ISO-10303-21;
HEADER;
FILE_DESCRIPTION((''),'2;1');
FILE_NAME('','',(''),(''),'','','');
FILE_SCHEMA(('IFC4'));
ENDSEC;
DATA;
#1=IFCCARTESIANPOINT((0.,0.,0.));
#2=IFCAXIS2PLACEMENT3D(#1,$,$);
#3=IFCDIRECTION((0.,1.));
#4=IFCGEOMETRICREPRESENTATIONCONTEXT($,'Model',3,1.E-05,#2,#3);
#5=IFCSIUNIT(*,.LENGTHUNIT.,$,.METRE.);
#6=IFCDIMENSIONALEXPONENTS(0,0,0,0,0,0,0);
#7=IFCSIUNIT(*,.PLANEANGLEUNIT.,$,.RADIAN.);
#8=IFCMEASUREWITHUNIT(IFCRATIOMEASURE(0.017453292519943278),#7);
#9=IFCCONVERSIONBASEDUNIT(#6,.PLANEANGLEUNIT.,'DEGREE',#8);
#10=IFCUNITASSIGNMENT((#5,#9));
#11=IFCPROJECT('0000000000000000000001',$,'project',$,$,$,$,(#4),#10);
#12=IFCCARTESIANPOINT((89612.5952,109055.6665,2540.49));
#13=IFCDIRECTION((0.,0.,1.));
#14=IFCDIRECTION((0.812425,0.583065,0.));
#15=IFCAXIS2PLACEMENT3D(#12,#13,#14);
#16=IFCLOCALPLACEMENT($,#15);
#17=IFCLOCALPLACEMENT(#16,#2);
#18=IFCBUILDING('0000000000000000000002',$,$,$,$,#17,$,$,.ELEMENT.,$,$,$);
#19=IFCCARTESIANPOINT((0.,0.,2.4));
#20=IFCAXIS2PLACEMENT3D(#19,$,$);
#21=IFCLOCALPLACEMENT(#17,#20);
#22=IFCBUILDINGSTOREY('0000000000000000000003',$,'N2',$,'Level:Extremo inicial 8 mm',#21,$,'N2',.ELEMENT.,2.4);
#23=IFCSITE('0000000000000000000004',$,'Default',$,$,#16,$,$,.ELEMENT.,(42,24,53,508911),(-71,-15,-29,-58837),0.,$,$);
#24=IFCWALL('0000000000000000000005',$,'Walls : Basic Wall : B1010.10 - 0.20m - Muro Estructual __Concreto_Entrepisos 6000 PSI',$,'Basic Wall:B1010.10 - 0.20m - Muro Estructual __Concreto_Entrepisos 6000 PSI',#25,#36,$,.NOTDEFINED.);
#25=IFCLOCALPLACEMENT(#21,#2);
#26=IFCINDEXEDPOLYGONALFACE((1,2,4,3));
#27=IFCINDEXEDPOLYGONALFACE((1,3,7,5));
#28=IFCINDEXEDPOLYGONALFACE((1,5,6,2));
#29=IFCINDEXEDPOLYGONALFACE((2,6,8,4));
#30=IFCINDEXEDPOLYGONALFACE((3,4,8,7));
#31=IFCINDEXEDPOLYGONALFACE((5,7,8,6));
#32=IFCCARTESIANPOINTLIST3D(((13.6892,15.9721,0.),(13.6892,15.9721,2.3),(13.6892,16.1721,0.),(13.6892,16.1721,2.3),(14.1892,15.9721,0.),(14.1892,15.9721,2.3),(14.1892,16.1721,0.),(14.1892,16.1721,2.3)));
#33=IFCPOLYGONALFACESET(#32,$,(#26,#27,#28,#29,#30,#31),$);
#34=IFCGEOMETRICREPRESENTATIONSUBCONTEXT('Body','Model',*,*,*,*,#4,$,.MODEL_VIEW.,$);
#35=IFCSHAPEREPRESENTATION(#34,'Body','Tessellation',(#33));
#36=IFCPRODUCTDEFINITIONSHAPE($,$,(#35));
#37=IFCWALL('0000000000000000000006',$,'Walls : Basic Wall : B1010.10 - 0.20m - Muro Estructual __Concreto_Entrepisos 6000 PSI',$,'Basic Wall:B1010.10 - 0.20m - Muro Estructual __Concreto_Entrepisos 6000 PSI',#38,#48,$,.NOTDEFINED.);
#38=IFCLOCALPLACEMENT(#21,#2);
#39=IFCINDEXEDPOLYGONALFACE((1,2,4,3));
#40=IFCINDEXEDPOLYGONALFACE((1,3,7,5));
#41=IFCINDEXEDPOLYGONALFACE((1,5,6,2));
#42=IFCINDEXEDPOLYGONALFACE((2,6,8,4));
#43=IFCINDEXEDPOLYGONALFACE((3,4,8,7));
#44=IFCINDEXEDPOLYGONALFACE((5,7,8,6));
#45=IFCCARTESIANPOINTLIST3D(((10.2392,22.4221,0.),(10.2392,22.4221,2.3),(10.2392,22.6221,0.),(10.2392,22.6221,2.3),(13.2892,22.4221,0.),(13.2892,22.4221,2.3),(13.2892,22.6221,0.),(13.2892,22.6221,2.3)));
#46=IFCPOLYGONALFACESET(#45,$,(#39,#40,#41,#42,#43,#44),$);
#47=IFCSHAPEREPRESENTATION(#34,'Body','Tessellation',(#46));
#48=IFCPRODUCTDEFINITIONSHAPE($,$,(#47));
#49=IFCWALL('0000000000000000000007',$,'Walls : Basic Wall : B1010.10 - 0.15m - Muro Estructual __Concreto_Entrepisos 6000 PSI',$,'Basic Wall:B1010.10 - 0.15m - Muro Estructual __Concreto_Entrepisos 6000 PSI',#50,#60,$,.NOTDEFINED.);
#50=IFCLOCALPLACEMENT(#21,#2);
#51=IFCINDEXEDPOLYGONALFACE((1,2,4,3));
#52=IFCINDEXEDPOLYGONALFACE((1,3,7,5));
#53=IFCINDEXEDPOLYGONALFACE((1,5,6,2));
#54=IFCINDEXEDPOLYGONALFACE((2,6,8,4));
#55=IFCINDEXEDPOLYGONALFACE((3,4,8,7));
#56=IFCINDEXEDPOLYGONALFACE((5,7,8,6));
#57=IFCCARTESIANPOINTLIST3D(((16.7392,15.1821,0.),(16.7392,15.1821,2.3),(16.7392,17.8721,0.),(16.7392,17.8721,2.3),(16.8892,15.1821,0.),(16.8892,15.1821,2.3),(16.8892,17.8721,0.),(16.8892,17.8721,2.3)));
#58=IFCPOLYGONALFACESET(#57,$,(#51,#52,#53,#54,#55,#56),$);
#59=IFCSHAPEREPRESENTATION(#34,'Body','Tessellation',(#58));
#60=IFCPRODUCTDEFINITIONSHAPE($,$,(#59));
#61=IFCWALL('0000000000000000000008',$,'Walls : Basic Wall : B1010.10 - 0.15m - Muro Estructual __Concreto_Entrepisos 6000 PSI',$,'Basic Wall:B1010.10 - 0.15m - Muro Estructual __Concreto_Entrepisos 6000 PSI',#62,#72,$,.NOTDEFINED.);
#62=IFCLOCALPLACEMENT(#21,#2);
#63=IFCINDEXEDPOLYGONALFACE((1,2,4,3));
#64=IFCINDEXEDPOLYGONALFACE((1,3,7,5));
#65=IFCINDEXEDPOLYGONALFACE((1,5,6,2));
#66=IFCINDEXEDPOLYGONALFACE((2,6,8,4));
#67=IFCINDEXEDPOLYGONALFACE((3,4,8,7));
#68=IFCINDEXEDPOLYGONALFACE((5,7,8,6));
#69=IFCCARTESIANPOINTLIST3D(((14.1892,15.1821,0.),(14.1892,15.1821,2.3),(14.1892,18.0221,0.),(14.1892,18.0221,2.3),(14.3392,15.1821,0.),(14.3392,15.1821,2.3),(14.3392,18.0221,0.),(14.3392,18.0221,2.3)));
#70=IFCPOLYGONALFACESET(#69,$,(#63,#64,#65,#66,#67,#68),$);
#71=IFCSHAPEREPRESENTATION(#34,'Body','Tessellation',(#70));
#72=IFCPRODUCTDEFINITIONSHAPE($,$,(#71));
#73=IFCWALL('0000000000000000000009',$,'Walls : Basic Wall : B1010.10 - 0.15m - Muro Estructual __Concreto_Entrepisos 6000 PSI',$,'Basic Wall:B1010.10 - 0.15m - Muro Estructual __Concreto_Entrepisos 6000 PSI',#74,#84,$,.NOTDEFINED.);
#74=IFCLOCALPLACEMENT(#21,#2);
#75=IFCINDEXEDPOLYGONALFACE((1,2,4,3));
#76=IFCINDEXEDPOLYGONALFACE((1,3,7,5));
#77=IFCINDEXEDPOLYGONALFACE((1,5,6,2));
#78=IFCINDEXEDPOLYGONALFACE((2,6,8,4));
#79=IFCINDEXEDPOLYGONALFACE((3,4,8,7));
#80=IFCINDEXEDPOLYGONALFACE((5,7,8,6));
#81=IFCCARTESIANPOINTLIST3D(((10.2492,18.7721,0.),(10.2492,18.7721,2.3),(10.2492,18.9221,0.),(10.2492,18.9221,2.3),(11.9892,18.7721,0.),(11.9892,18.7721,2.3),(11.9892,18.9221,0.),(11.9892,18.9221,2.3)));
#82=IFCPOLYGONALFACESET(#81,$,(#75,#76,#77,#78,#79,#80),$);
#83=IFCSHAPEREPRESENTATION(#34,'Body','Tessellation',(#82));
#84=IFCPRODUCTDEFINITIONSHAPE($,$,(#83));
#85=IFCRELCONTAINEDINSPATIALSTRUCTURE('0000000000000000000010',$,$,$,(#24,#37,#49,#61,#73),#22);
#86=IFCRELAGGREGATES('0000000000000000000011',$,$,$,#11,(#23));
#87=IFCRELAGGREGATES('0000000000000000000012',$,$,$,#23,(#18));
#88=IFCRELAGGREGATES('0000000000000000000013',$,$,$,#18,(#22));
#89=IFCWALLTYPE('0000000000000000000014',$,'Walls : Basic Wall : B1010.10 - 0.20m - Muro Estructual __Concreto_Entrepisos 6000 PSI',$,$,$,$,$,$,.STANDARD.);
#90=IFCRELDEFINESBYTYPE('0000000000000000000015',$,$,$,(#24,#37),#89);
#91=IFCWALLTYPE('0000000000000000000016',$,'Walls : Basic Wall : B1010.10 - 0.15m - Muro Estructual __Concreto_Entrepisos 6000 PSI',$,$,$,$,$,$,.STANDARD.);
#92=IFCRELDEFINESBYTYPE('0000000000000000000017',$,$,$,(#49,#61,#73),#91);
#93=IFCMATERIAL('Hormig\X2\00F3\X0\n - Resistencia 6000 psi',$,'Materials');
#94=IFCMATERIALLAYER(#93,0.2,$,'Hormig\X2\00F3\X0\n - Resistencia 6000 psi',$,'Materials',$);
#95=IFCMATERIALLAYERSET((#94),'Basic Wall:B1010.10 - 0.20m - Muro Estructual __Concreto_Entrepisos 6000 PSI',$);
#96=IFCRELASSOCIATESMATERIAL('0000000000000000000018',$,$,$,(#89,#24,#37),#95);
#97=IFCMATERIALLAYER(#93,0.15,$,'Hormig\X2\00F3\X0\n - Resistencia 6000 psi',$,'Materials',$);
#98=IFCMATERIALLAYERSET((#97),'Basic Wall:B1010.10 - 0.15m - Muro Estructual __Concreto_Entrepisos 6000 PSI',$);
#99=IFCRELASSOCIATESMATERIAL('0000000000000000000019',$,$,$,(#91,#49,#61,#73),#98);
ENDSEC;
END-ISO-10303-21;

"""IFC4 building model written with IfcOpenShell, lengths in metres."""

from ifc_helpers import new_model, entity, si_unit, converted_unit, direction, frame, frame_2d, origin, place, context, subcontext, project, spatial, rectangle, extrude, material, layer, layer_set, layer_usage, type_object, element, save


model = new_model("IFC4")

# Units and contexts
model_context = context("Model", 3, precision=1e-05, world=origin(), true_north=direction((0.0, 1.0)))
body_context = subcontext(model_context, "Body", "Model", "MODEL_VIEW")
ifc_project = project(units=[si_unit("LENGTHUNIT", "METRE"), converted_unit("PLANEANGLEUNIT", "DEGREE", entity("IfcRatioMeasure", 0.017453292519943278), si_unit("PLANEANGLEUNIT", "RADIAN"), dimensions=[0, 0, 0, 0, 0, 0, 0])], contexts=[model_context])

# Site, building, storey
site_placement = place(None, frame((89612.5952, 109055.6665, 2540.49), z_axis=(0.0, 0.0, 1.0), x_axis=(0.812425, 0.583065, 0.0)))
site = spatial("IfcSite", under=ifc_project, at=site_placement, Name="Default", CompositionType="ELEMENT", RefLatitude=(42, 24, 53, 508911), RefLongitude=(-71, -15, -29, -58837), RefElevation=0.0)
building_placement = place(site_placement, origin())
building = spatial("IfcBuilding", under=site, at=building_placement, CompositionType="ELEMENT")
storey_placement = place(building_placement, frame((0.0, 0.0, 2.4)))
storey = spatial("IfcBuildingStorey", under=building, at=storey_placement, Name="N2", ObjectType="Level:Extremo inicial 8 mm", LongName="N2", CompositionType="ELEMENT", Elevation=2.4)

# Walls
ifc_material_1 = material(Name="Hormigón - Resistencia 6000 psi", Category="Materials")
ifc_layer_1 = layer(ifc_material_1, 0.2, Name="Hormigón - Resistencia 6000 psi", Category="Materials")
ifc_layer_set_1 = layer_set([ifc_layer_1], Name="Basic Wall:B1010.10 - 0.20m - Muro Estructual __Concreto_Entrepisos 6000 PSI")
wall_type_1 = type_object("IfcWallType", Name="Walls : Basic Wall : B1010.10 - 0.20m - Muro Estructual __Concreto_Entrepisos 6000 PSI", PredefinedType="STANDARD", material=ifc_layer_set_1)
ifc_layer_usage_1 = layer_usage(ifc_layer_set_1, "AXIS2", "NEGATIVE", 0.1)
wall_1_placement = place(storey_placement, frame((13.6892, 16.0721, 0.0)))
element("IfcWall", 1, at=wall_1_placement, inside=storey, type_object=wall_type_1, material=ifc_layer_usage_1, Name="Walls : Basic Wall : B1010.10 - 0.20m - Muro Estructual __Concreto_Entrepisos 6000 PSI", ObjectType="Basic Wall:B1010.10 - 0.20m - Muro Estructual __Concreto_Entrepisos 6000 PSI", PredefinedType="NOTDEFINED", context=body_context, shape_type="SweptSolid", body=[
    extrude(rectangle(XDim=0.5, YDim=0.2, at=frame_2d((0.25, 0.0), x_axis=(-1.0, 0.0))), origin(), (0.0, 0.0, 1.0), 2.3),
])
ifc_layer_usage_2 = layer_usage(ifc_layer_set_1, "AXIS2", "POSITIVE", -0.1)
wall_2_placement = place(storey_placement, frame((10.2392, 22.5221, 0.0)))
element("IfcWall", 2, at=wall_2_placement, inside=storey, type_object=wall_type_1, material=ifc_layer_usage_2, Name="Walls : Basic Wall : B1010.10 - 0.20m - Muro Estructual __Concreto_Entrepisos 6000 PSI", ObjectType="Basic Wall:B1010.10 - 0.20m - Muro Estructual __Concreto_Entrepisos 6000 PSI", PredefinedType="NOTDEFINED", context=body_context, shape_type="SweptSolid", body=[
    extrude(rectangle(XDim=3.05, YDim=0.2, at=frame_2d((1.525, 0.0), x_axis=(-1.0, 0.0))), origin(), (0.0, 0.0, 1.0), 2.3),
])
ifc_layer_2 = layer(ifc_material_1, 0.15, Name="Hormigón - Resistencia 6000 psi", Category="Materials")
ifc_layer_set_2 = layer_set([ifc_layer_2], Name="Basic Wall:B1010.10 - 0.15m - Muro Estructual __Concreto_Entrepisos 6000 PSI")
ifc_layer_usage_3 = layer_usage(ifc_layer_set_2, "AXIS2", "NEGATIVE", 0.075)
wall_type_2 = type_object("IfcWallType", Name="Walls : Basic Wall : B1010.10 - 0.15m - Muro Estructual __Concreto_Entrepisos 6000 PSI", PredefinedType="STANDARD", material=ifc_layer_set_2)
wall_3_placement = place(storey_placement, frame((16.8142, 15.1821, 0.0), z_axis=(0.0, 0.0, 1.0), x_axis=(0.0, 1.0, 0.0)))
element("IfcWall", 3, at=wall_3_placement, inside=storey, type_object=wall_type_2, material=ifc_layer_usage_3, Name="Walls : Basic Wall : B1010.10 - 0.15m - Muro Estructual __Concreto_Entrepisos 6000 PSI", ObjectType="Basic Wall:B1010.10 - 0.15m - Muro Estructual __Concreto_Entrepisos 6000 PSI", PredefinedType="NOTDEFINED", context=body_context, shape_type="SweptSolid", body=[
    extrude(rectangle(XDim=2.69, YDim=0.15, at=frame_2d((1.345, 0.0), x_axis=(-1.0, 0.0))), origin(), (0.0, 0.0, 1.0), 2.3),
])
ifc_layer_usage_4 = layer_usage(ifc_layer_set_2, "AXIS2", "NEGATIVE", 0.075)
wall_4_placement = place(storey_placement, frame((14.2642, 15.1821, 0.0), z_axis=(0.0, 0.0, 1.0), x_axis=(0.0, 1.0, 0.0)))
element("IfcWall", 4, at=wall_4_placement, inside=storey, type_object=wall_type_2, material=ifc_layer_usage_4, Name="Walls : Basic Wall : B1010.10 - 0.15m - Muro Estructual __Concreto_Entrepisos 6000 PSI", ObjectType="Basic Wall:B1010.10 - 0.15m - Muro Estructual __Concreto_Entrepisos 6000 PSI", PredefinedType="NOTDEFINED", context=body_context, shape_type="SweptSolid", body=[
    extrude(rectangle(XDim=2.84, YDim=0.15, at=frame_2d((1.42, 0.0), x_axis=(-1.0, 0.0))), origin(), (0.0, 0.0, 1.0), 2.3),
])
ifc_layer_usage_5 = layer_usage(ifc_layer_set_2, "AXIS2", "NEGATIVE", 0.075)
wall_5_placement = place(storey_placement, frame((11.9892, 18.8471, 0.0), z_axis=(0.0, 0.0, 1.0), x_axis=(-1.0, 0.0, 0.0)))
element("IfcWall", 5, at=wall_5_placement, inside=storey, type_object=wall_type_2, material=ifc_layer_usage_5, Name="Walls : Basic Wall : B1010.10 - 0.15m - Muro Estructual __Concreto_Entrepisos 6000 PSI", ObjectType="Basic Wall:B1010.10 - 0.15m - Muro Estructual __Concreto_Entrepisos 6000 PSI", PredefinedType="NOTDEFINED", context=body_context, shape_type="SweptSolid", body=[
    extrude(rectangle(XDim=1.74, YDim=0.15, at=frame_2d((0.87, 0.0), x_axis=(-1.0, 0.0))), origin(), (0.0, 0.0, 1.0), 2.3),
])

save(model, "model.ifc")
